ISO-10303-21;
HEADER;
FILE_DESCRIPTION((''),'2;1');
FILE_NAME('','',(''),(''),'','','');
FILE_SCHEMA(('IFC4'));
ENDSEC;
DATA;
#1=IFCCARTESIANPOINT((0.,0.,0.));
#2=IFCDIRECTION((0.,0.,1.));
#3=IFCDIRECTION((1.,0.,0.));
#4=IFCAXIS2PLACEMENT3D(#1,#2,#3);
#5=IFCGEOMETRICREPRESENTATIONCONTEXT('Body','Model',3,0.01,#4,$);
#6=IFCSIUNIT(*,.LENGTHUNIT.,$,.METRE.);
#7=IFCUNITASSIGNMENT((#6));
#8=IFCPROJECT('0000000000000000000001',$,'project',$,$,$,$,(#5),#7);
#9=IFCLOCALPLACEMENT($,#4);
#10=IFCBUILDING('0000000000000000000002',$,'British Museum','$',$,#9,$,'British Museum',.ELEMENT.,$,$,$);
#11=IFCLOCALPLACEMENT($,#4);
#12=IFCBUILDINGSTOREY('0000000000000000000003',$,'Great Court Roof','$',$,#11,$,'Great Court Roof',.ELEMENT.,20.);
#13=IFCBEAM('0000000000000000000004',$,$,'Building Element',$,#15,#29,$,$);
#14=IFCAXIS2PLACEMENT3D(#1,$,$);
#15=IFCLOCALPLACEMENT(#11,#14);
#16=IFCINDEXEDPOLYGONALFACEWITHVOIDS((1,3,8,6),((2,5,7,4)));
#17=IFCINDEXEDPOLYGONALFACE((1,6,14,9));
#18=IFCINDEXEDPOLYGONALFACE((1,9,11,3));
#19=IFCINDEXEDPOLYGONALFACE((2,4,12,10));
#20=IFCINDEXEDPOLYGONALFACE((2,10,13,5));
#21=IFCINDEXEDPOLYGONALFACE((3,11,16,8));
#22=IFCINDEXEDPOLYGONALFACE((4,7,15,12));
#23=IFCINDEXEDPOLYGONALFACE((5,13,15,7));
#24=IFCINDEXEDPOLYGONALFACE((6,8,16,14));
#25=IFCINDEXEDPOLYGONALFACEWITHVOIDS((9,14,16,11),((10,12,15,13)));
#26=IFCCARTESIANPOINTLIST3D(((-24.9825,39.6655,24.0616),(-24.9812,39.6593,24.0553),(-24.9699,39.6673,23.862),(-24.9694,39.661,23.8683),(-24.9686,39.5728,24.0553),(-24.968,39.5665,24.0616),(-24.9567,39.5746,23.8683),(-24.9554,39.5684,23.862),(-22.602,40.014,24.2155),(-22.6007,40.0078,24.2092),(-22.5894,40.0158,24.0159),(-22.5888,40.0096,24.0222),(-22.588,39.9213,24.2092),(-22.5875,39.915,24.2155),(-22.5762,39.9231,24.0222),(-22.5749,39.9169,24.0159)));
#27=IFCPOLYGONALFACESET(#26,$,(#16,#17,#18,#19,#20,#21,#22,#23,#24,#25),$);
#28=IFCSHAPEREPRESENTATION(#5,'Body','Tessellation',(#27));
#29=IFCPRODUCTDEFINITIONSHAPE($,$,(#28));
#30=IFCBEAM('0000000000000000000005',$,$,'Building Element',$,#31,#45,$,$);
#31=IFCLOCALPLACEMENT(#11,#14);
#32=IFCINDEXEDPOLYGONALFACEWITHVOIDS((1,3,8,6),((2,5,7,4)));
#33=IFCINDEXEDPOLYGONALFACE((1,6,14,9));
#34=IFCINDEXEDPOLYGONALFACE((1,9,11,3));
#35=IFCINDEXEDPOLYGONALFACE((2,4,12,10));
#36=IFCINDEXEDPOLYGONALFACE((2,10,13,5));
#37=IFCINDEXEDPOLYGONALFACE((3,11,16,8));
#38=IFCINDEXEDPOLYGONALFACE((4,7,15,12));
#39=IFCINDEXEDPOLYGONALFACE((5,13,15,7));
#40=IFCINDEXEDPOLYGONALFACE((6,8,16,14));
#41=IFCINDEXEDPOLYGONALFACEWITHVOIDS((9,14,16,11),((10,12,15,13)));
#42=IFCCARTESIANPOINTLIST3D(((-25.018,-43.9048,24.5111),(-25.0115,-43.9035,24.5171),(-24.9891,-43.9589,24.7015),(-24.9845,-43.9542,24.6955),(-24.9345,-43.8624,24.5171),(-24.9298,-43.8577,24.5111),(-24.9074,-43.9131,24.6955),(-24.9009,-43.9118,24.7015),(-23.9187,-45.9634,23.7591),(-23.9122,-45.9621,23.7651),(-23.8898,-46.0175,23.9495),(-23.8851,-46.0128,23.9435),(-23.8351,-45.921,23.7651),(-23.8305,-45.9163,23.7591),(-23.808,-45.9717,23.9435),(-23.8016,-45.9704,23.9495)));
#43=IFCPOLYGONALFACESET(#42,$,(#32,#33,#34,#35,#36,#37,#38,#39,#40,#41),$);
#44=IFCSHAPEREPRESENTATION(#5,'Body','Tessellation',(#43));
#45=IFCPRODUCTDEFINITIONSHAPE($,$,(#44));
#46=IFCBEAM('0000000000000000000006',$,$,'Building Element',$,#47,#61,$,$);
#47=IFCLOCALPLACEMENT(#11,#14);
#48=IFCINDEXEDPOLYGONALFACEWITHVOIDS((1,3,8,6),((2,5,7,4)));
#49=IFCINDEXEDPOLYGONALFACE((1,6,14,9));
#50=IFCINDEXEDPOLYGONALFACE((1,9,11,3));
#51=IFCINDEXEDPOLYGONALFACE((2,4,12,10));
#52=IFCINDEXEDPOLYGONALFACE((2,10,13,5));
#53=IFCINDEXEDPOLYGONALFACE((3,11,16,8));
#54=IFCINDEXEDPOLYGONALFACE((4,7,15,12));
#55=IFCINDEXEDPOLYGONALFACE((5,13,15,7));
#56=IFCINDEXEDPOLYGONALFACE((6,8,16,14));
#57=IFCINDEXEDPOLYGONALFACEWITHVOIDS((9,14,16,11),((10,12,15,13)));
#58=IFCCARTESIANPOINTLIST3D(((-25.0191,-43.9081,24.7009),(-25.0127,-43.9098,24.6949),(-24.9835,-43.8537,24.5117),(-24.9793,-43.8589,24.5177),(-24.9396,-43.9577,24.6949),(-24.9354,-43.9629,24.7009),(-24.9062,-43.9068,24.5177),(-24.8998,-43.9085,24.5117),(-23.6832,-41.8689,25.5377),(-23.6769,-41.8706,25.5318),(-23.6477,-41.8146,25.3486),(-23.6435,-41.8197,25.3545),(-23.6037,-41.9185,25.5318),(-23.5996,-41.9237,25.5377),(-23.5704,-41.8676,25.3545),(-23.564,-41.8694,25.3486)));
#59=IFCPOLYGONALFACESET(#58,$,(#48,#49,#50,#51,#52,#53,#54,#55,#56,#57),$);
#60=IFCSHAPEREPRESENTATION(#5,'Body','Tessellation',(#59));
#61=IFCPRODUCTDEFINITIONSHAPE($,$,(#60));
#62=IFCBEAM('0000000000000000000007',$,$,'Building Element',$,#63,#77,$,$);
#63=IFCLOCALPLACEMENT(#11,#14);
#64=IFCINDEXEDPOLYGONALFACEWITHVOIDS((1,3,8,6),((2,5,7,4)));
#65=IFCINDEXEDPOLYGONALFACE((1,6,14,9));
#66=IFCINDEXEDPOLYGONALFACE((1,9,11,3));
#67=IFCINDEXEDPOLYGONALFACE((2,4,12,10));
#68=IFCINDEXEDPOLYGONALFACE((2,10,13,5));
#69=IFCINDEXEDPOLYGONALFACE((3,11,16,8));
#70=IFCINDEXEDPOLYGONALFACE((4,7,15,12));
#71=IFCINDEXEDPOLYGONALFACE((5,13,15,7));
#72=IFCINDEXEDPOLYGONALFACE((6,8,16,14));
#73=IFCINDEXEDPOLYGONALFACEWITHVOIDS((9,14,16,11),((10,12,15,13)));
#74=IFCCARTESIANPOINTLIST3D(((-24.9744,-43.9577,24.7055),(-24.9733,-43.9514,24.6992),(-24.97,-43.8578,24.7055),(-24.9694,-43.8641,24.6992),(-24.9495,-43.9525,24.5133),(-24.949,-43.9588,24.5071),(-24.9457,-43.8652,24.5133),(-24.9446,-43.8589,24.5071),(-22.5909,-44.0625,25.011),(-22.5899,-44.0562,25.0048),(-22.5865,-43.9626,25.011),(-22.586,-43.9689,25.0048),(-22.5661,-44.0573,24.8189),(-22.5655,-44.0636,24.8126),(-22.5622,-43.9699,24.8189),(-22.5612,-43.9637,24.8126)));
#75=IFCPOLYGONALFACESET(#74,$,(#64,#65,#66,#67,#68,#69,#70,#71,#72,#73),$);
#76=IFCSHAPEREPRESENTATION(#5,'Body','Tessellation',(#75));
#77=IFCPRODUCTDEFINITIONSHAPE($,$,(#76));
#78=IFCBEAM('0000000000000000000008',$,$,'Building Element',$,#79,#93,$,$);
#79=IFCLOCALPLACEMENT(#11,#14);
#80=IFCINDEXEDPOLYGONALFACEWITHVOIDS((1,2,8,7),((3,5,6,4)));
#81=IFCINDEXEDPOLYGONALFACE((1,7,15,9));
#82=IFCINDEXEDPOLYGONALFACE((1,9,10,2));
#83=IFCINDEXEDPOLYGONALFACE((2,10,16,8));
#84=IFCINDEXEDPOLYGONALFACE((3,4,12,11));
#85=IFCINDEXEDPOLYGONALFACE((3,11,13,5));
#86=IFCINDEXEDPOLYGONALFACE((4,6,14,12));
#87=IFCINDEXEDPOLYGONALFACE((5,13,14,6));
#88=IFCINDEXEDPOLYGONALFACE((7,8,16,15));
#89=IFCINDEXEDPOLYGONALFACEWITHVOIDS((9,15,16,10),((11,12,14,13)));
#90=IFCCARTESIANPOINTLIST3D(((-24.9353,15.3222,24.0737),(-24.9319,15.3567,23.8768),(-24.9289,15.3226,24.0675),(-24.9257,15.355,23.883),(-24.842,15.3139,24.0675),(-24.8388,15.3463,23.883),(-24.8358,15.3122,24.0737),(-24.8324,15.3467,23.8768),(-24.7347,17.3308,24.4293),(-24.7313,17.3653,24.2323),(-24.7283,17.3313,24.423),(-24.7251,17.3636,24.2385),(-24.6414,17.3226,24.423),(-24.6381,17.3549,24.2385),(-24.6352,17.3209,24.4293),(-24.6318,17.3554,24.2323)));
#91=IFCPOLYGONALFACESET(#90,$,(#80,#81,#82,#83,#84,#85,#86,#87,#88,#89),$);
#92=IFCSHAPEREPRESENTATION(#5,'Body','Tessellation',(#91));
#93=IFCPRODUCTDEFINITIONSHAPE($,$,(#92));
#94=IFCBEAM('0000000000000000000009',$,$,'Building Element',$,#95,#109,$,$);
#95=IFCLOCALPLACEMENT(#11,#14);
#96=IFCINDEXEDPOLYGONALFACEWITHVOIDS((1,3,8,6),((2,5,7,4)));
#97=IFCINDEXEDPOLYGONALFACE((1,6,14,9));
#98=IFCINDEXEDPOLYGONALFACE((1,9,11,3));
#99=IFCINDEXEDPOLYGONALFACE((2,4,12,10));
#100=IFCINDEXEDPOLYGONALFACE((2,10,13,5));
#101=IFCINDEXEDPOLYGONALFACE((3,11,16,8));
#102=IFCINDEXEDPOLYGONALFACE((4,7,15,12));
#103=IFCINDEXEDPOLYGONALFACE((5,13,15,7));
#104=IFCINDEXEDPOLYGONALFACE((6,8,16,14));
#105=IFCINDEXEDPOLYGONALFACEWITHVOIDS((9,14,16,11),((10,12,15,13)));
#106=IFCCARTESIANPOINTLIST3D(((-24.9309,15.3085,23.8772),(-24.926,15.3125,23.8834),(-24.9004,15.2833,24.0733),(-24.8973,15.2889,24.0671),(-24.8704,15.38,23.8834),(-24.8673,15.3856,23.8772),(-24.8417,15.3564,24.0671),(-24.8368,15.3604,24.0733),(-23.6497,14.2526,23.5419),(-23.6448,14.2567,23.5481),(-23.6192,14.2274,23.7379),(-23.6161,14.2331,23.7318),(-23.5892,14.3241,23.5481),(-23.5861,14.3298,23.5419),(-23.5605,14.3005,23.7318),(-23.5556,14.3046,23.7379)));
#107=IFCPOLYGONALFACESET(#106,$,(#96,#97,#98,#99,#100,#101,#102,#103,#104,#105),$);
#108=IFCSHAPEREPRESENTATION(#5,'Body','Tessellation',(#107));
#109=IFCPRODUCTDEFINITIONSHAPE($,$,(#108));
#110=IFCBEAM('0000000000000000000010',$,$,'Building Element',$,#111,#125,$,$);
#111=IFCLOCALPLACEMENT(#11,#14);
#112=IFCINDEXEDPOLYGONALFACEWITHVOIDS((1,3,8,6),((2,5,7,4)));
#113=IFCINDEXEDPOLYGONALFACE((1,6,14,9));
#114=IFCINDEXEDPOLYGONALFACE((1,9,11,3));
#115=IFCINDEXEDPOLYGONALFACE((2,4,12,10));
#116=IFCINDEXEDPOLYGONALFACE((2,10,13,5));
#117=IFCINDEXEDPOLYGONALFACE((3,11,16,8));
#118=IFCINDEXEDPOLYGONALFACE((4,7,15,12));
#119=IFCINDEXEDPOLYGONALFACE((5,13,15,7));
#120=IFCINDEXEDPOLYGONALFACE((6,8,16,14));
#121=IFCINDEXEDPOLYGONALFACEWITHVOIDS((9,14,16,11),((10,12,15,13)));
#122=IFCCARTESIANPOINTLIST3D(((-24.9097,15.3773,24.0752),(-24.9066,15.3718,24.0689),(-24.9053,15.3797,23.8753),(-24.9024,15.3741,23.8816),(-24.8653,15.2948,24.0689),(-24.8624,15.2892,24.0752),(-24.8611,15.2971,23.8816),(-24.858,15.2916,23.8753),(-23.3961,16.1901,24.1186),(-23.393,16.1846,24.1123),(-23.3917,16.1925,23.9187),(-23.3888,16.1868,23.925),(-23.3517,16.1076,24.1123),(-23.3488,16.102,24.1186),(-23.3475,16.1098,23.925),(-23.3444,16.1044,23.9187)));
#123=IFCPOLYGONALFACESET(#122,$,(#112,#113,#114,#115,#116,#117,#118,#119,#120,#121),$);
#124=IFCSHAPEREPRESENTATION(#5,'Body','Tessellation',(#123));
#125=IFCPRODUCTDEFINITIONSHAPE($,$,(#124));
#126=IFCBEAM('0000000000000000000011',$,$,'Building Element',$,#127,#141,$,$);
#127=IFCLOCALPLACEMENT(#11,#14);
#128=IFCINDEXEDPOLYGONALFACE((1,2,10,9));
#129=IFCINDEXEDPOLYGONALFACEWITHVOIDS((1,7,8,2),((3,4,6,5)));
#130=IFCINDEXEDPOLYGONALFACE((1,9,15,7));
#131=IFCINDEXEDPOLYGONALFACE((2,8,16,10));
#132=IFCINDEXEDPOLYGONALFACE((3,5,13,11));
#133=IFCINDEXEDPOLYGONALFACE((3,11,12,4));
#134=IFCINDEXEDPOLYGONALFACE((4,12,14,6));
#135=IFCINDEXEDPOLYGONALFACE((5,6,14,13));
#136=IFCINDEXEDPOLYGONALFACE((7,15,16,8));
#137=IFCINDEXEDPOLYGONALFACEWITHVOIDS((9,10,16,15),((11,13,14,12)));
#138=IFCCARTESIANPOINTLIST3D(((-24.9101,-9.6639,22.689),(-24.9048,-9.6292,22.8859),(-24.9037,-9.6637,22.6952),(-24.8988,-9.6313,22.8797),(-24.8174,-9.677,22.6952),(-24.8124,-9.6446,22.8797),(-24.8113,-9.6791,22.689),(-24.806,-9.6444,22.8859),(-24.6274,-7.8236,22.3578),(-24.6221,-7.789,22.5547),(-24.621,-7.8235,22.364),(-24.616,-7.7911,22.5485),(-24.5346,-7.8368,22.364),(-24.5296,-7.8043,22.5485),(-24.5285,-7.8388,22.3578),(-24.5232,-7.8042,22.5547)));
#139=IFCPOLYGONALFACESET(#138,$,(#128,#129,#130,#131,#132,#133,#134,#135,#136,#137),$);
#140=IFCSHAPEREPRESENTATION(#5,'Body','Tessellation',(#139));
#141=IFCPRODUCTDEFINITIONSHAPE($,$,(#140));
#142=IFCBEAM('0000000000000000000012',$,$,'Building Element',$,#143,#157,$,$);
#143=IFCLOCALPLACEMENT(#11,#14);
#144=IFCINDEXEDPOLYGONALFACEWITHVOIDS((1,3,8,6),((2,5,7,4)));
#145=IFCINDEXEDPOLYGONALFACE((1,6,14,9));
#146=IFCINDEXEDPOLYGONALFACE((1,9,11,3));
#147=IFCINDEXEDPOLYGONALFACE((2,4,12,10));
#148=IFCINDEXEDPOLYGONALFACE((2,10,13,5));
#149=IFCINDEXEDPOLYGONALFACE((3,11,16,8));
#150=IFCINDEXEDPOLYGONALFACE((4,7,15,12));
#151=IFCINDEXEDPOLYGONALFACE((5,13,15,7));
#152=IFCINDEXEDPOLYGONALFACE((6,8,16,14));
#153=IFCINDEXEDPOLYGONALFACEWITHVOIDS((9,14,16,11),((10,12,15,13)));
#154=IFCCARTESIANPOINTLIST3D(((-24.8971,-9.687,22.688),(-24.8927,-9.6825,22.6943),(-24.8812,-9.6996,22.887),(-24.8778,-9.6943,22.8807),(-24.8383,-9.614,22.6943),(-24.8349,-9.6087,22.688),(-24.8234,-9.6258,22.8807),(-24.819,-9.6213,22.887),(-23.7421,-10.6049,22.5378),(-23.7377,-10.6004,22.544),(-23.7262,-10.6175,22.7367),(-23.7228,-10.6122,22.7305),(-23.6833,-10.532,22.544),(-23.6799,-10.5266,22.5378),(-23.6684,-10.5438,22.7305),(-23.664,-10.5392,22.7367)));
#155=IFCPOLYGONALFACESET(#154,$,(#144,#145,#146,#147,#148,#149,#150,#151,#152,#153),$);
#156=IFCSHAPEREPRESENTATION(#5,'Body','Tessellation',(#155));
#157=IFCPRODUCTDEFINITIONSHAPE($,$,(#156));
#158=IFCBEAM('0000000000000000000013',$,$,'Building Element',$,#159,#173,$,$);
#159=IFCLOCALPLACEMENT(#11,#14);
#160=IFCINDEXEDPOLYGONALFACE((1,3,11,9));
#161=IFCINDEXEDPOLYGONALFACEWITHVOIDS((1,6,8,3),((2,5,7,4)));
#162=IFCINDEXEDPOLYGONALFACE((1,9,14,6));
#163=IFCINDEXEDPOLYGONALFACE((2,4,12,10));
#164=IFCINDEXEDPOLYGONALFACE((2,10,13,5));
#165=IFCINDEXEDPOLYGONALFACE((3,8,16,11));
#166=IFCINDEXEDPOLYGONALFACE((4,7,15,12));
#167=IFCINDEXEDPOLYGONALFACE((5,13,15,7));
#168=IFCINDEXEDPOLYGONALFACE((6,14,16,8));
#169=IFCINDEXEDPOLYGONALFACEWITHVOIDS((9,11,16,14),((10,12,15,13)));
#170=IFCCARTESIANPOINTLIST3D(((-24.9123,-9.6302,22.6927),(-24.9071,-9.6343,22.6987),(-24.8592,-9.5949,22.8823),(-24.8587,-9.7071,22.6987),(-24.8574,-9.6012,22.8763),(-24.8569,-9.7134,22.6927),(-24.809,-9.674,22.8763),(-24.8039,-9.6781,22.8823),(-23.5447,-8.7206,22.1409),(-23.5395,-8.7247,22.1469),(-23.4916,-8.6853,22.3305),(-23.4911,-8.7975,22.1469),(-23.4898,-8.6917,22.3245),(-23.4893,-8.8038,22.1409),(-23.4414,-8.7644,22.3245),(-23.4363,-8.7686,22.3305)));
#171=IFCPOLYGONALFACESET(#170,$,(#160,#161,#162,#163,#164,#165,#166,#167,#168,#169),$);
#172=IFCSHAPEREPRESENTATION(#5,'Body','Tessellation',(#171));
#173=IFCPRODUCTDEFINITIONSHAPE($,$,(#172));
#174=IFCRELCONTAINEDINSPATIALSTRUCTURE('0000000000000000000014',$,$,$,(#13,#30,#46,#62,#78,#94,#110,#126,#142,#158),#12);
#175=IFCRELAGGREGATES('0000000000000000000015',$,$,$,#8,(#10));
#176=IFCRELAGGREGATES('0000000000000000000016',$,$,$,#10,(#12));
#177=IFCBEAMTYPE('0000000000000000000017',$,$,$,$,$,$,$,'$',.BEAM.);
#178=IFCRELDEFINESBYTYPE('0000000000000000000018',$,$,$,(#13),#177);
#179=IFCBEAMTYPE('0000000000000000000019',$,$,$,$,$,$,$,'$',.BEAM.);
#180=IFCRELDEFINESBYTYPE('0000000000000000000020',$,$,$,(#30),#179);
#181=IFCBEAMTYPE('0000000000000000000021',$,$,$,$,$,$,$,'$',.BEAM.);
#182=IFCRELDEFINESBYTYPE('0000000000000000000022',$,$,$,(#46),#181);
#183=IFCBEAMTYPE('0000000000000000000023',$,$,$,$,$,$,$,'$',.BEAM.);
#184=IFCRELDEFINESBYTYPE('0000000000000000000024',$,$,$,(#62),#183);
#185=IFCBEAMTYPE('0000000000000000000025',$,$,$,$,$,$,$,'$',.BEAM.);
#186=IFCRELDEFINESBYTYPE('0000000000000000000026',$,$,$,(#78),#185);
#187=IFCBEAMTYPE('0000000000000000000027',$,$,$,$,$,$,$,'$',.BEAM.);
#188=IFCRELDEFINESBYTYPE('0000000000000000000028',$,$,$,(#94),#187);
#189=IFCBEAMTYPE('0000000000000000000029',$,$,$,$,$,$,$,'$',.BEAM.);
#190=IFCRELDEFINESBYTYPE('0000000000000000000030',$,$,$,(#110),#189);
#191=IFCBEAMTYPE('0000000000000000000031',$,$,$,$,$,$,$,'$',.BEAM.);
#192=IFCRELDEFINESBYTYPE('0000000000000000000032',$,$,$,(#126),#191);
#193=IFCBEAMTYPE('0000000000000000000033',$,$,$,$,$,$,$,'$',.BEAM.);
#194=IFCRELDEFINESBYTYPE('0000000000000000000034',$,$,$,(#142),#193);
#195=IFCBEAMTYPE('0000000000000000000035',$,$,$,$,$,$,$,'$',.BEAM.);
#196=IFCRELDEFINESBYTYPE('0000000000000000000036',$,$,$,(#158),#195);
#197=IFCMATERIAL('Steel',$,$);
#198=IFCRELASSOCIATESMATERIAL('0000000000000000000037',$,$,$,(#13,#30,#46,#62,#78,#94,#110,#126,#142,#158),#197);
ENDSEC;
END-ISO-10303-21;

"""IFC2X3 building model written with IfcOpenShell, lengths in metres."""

from ifc_helpers import new_model, si_unit, frame, origin_with_axes, origin_2d, place, context, project, spatial, hollow_rectangle, extrude, material, type_object, element, save


model = new_model("IFC2X3")

# Units and contexts
model_context = context("Model", 3, precision=0.01, world=origin_with_axes(), identifier="Body")
ifc_project = project(units=[si_unit("LENGTHUNIT", "METRE")], contexts=[model_context])

# Building, storey
building_placement = place(None, origin_with_axes())
building = spatial("IfcBuilding", under=ifc_project, at=building_placement, Name="British Museum", Description="$", LongName="British Museum", CompositionType="ELEMENT")
storey_placement = place(None, origin_with_axes())
storey = spatial("IfcBuildingStorey", under=building, at=storey_placement, Name="Great Court Roof", Description="$", LongName="Great Court Roof", CompositionType="ELEMENT", Elevation=20.0)

# Beams
ifc_material = material(Name="Steel")
beam_type_1 = type_object("IfcBeamType", ElementType="$", PredefinedType="BEAM")
beam_1_placement = place(None, origin_with_axes())
element("IfcBeam", 1, at=beam_1_placement, inside=storey, type_object=beam_type_1, material=ifc_material, Description="Building Element", context=model_context, shape_type="SweptSolid", body=[
    extrude(hollow_rectangle(XDim=0.1, YDim=0.2, WallThickness=0.0063, InnerFilletRadius=-0.0063, OuterFilletRadius=0.0, at=origin_2d()), frame((-24.969, 39.6169, 23.9618), z_axis=(0.987433, 0.144565, 0.063845), x_axis=(-0.14486, 0.989452, 0.0)), (0.0, 0.0, 1.0), 2.4108),
])
beam_type_2 = type_object("IfcBeamType", ElementType="$", PredefinedType="BEAM")
beam_2_placement = place(None, origin_with_axes())
element("IfcBeam", 2, at=beam_2_placement, inside=storey, type_object=beam_type_2, material=ifc_material, Description="Building Element", context=model_context, shape_type="SweptSolid", body=[
    extrude(hollow_rectangle(XDim=0.1, YDim=0.2, WallThickness=0.0063, InnerFilletRadius=-0.0063, OuterFilletRadius=0.0, at=origin_2d()), frame((-24.9595, -43.9083, 24.6063), z_axis=(0.448362, -0.839591, -0.306689), x_axis=(0.8821, 0.471063, 0.0)), (0.0, 0.0, 1.0), 2.4519),
])
beam_type_3 = type_object("IfcBeamType", ElementType="$", PredefinedType="BEAM")
beam_3_placement = place(None, origin_with_axes())
element("IfcBeam", 3, at=beam_3_placement, inside=storey, type_object=beam_type_3, material=ifc_material, Description="Building Element", context=model_context, shape_type="SweptSolid", body=[
    extrude(hollow_rectangle(XDim=0.1, YDim=0.2, WallThickness=0.0063, InnerFilletRadius=-0.0063, OuterFilletRadius=0.0, at=origin_2d()), frame((-24.9595, -43.9083, 24.6063), z_axis=(0.518285, 0.791173, 0.324694), x_axis=(-0.836495, 0.547974, 0.0)), (0.0, 0.0, 1.0), 2.5774),
])
beam_type_4 = type_object("IfcBeamType", ElementType="$", PredefinedType="BEAM")
beam_4_placement = place(None, origin_with_axes())
element("IfcBeam", 4, at=beam_4_placement, inside=storey, type_object=beam_type_4, material=ifc_material, Description="Building Element", context=model_context, shape_type="SweptSolid", body=[
    extrude(hollow_rectangle(XDim=0.1, YDim=0.2, WallThickness=0.0063, InnerFilletRadius=-0.0063, OuterFilletRadius=0.0, at=origin_2d()), frame((-24.9595, -43.9083, 24.6063), z_axis=(0.990941, -0.043558, 0.127037), x_axis=(0.043914, 0.999035, 0.0)), (0.0, 0.0, 1.0), 2.4052),
])
beam_type_5 = type_object("IfcBeamType", ElementType="$", PredefinedType="BEAM")
beam_5_placement = place(None, origin_with_axes())
element("IfcBeam", 5, at=beam_5_placement, inside=storey, type_object=beam_type_5, material=ifc_material, Description="Building Element", context=model_context, shape_type="SweptSolid", body=[
    extrude(hollow_rectangle(XDim=0.1, YDim=0.2, WallThickness=0.0063, InnerFilletRadius=-0.0063, OuterFilletRadius=0.0, at=origin_2d()), frame((-24.8838, 15.3345, 23.9752), z_axis=(0.09787, 0.979968, 0.173449), x_axis=(-0.99505, 0.099376, 0.0)), (0.0, 0.0, 1.0), 2.0497),
])
beam_type_6 = type_object("IfcBeamType", ElementType="$", PredefinedType="BEAM")
beam_6_placement = place(None, origin_with_axes())
element("IfcBeam", 6, at=beam_6_placement, inside=storey, type_object=beam_type_6, material=ifc_material, Description="Building Element", context=model_context, shape_type="SweptSolid", body=[
    extrude(hollow_rectangle(XDim=0.1, YDim=0.2, WallThickness=0.0063, InnerFilletRadius=-0.0063, OuterFilletRadius=0.0, at=origin_2d()), frame((-24.8838, 15.3345, 23.9752), z_axis=(0.756433, -0.623387, -0.197983), x_axis=(0.635976, 0.771709, 0.0)), (0.0, 0.0, 1.0), 1.6937),
])
beam_type_7 = type_object("IfcBeamType", ElementType="$", PredefinedType="BEAM")
beam_7_placement = place(None, origin_with_axes())
element("IfcBeam", 7, at=beam_7_placement, inside=storey, type_object=beam_type_7, material=ifc_material, Description="Building Element", context=model_context, shape_type="SweptSolid", body=[
    extrude(hollow_rectangle(XDim=0.1, YDim=0.2, WallThickness=0.0063, InnerFilletRadius=-0.0063, OuterFilletRadius=0.0, at=origin_2d()), frame((-24.8838, 15.3345, 23.9752), z_axis=(0.880734, 0.472937, 0.025252), x_axis=(-0.473088, 0.881015, 0.0)), (0.0, 0.0, 1.0), 1.7186),
])
beam_type_8 = type_object("IfcBeamType", ElementType="$", PredefinedType="BEAM")
beam_8_placement = place(None, origin_with_axes())
element("IfcBeam", 8, at=beam_8_placement, inside=storey, type_object=beam_type_8, material=ifc_material, Description="Building Element", context=model_context, shape_type="SweptSolid", body=[
    extrude(hollow_rectangle(XDim=0.1, YDim=0.2, WallThickness=0.0063, InnerFilletRadius=-0.0063, OuterFilletRadius=0.0, at=origin_2d()), frame((-24.8581, -9.6541, 22.7875), z_axis=(0.149523, 0.973117, -0.175174), x_axis=(-0.9884, 0.151872, 0.0)), (0.0, 0.0, 1.0), 1.8911),
])
beam_type_9 = type_object("IfcBeamType", ElementType="$", PredefinedType="BEAM")
beam_9_placement = place(None, origin_with_axes())
element("IfcBeam", 9, at=beam_9_placement, inside=storey, type_object=beam_type_9, material=ifc_material, Description="Building Element", context=model_context, shape_type="SweptSolid", body=[
    extrude(hollow_rectangle(XDim=0.1, YDim=0.2, WallThickness=0.0063, InnerFilletRadius=-0.0063, OuterFilletRadius=0.0, at=origin_2d()), frame((-24.8581, -9.6541, 22.7875), z_axis=(0.778847, -0.618977, -0.101312), x_axis=(0.622179, 0.782875, 0.0)), (0.0, 0.0, 1.0), 1.483),
])
beam_type_10 = type_object("IfcBeamType", ElementType="$", PredefinedType="BEAM")
beam_10_placement = place(None, origin_with_axes())
element("IfcBeam", 10, at=beam_10_placement, inside=storey, type_object=beam_type_10, material=ifc_material, Description="Building Element", context=model_context, shape_type="SweptSolid", body=[
    extrude(hollow_rectangle(XDim=0.1, YDim=0.2, WallThickness=0.0063, InnerFilletRadius=-0.0063, OuterFilletRadius=0.0, at=origin_2d()), frame((-24.8581, -9.6541, 22.7875), z_axis=(0.789302, 0.524959, -0.318466), x_axis=(-0.553792, 0.832655, 0.0)), (0.0, 0.0, 1.0), 1.7327),
])

save(model, "model.ifc")
